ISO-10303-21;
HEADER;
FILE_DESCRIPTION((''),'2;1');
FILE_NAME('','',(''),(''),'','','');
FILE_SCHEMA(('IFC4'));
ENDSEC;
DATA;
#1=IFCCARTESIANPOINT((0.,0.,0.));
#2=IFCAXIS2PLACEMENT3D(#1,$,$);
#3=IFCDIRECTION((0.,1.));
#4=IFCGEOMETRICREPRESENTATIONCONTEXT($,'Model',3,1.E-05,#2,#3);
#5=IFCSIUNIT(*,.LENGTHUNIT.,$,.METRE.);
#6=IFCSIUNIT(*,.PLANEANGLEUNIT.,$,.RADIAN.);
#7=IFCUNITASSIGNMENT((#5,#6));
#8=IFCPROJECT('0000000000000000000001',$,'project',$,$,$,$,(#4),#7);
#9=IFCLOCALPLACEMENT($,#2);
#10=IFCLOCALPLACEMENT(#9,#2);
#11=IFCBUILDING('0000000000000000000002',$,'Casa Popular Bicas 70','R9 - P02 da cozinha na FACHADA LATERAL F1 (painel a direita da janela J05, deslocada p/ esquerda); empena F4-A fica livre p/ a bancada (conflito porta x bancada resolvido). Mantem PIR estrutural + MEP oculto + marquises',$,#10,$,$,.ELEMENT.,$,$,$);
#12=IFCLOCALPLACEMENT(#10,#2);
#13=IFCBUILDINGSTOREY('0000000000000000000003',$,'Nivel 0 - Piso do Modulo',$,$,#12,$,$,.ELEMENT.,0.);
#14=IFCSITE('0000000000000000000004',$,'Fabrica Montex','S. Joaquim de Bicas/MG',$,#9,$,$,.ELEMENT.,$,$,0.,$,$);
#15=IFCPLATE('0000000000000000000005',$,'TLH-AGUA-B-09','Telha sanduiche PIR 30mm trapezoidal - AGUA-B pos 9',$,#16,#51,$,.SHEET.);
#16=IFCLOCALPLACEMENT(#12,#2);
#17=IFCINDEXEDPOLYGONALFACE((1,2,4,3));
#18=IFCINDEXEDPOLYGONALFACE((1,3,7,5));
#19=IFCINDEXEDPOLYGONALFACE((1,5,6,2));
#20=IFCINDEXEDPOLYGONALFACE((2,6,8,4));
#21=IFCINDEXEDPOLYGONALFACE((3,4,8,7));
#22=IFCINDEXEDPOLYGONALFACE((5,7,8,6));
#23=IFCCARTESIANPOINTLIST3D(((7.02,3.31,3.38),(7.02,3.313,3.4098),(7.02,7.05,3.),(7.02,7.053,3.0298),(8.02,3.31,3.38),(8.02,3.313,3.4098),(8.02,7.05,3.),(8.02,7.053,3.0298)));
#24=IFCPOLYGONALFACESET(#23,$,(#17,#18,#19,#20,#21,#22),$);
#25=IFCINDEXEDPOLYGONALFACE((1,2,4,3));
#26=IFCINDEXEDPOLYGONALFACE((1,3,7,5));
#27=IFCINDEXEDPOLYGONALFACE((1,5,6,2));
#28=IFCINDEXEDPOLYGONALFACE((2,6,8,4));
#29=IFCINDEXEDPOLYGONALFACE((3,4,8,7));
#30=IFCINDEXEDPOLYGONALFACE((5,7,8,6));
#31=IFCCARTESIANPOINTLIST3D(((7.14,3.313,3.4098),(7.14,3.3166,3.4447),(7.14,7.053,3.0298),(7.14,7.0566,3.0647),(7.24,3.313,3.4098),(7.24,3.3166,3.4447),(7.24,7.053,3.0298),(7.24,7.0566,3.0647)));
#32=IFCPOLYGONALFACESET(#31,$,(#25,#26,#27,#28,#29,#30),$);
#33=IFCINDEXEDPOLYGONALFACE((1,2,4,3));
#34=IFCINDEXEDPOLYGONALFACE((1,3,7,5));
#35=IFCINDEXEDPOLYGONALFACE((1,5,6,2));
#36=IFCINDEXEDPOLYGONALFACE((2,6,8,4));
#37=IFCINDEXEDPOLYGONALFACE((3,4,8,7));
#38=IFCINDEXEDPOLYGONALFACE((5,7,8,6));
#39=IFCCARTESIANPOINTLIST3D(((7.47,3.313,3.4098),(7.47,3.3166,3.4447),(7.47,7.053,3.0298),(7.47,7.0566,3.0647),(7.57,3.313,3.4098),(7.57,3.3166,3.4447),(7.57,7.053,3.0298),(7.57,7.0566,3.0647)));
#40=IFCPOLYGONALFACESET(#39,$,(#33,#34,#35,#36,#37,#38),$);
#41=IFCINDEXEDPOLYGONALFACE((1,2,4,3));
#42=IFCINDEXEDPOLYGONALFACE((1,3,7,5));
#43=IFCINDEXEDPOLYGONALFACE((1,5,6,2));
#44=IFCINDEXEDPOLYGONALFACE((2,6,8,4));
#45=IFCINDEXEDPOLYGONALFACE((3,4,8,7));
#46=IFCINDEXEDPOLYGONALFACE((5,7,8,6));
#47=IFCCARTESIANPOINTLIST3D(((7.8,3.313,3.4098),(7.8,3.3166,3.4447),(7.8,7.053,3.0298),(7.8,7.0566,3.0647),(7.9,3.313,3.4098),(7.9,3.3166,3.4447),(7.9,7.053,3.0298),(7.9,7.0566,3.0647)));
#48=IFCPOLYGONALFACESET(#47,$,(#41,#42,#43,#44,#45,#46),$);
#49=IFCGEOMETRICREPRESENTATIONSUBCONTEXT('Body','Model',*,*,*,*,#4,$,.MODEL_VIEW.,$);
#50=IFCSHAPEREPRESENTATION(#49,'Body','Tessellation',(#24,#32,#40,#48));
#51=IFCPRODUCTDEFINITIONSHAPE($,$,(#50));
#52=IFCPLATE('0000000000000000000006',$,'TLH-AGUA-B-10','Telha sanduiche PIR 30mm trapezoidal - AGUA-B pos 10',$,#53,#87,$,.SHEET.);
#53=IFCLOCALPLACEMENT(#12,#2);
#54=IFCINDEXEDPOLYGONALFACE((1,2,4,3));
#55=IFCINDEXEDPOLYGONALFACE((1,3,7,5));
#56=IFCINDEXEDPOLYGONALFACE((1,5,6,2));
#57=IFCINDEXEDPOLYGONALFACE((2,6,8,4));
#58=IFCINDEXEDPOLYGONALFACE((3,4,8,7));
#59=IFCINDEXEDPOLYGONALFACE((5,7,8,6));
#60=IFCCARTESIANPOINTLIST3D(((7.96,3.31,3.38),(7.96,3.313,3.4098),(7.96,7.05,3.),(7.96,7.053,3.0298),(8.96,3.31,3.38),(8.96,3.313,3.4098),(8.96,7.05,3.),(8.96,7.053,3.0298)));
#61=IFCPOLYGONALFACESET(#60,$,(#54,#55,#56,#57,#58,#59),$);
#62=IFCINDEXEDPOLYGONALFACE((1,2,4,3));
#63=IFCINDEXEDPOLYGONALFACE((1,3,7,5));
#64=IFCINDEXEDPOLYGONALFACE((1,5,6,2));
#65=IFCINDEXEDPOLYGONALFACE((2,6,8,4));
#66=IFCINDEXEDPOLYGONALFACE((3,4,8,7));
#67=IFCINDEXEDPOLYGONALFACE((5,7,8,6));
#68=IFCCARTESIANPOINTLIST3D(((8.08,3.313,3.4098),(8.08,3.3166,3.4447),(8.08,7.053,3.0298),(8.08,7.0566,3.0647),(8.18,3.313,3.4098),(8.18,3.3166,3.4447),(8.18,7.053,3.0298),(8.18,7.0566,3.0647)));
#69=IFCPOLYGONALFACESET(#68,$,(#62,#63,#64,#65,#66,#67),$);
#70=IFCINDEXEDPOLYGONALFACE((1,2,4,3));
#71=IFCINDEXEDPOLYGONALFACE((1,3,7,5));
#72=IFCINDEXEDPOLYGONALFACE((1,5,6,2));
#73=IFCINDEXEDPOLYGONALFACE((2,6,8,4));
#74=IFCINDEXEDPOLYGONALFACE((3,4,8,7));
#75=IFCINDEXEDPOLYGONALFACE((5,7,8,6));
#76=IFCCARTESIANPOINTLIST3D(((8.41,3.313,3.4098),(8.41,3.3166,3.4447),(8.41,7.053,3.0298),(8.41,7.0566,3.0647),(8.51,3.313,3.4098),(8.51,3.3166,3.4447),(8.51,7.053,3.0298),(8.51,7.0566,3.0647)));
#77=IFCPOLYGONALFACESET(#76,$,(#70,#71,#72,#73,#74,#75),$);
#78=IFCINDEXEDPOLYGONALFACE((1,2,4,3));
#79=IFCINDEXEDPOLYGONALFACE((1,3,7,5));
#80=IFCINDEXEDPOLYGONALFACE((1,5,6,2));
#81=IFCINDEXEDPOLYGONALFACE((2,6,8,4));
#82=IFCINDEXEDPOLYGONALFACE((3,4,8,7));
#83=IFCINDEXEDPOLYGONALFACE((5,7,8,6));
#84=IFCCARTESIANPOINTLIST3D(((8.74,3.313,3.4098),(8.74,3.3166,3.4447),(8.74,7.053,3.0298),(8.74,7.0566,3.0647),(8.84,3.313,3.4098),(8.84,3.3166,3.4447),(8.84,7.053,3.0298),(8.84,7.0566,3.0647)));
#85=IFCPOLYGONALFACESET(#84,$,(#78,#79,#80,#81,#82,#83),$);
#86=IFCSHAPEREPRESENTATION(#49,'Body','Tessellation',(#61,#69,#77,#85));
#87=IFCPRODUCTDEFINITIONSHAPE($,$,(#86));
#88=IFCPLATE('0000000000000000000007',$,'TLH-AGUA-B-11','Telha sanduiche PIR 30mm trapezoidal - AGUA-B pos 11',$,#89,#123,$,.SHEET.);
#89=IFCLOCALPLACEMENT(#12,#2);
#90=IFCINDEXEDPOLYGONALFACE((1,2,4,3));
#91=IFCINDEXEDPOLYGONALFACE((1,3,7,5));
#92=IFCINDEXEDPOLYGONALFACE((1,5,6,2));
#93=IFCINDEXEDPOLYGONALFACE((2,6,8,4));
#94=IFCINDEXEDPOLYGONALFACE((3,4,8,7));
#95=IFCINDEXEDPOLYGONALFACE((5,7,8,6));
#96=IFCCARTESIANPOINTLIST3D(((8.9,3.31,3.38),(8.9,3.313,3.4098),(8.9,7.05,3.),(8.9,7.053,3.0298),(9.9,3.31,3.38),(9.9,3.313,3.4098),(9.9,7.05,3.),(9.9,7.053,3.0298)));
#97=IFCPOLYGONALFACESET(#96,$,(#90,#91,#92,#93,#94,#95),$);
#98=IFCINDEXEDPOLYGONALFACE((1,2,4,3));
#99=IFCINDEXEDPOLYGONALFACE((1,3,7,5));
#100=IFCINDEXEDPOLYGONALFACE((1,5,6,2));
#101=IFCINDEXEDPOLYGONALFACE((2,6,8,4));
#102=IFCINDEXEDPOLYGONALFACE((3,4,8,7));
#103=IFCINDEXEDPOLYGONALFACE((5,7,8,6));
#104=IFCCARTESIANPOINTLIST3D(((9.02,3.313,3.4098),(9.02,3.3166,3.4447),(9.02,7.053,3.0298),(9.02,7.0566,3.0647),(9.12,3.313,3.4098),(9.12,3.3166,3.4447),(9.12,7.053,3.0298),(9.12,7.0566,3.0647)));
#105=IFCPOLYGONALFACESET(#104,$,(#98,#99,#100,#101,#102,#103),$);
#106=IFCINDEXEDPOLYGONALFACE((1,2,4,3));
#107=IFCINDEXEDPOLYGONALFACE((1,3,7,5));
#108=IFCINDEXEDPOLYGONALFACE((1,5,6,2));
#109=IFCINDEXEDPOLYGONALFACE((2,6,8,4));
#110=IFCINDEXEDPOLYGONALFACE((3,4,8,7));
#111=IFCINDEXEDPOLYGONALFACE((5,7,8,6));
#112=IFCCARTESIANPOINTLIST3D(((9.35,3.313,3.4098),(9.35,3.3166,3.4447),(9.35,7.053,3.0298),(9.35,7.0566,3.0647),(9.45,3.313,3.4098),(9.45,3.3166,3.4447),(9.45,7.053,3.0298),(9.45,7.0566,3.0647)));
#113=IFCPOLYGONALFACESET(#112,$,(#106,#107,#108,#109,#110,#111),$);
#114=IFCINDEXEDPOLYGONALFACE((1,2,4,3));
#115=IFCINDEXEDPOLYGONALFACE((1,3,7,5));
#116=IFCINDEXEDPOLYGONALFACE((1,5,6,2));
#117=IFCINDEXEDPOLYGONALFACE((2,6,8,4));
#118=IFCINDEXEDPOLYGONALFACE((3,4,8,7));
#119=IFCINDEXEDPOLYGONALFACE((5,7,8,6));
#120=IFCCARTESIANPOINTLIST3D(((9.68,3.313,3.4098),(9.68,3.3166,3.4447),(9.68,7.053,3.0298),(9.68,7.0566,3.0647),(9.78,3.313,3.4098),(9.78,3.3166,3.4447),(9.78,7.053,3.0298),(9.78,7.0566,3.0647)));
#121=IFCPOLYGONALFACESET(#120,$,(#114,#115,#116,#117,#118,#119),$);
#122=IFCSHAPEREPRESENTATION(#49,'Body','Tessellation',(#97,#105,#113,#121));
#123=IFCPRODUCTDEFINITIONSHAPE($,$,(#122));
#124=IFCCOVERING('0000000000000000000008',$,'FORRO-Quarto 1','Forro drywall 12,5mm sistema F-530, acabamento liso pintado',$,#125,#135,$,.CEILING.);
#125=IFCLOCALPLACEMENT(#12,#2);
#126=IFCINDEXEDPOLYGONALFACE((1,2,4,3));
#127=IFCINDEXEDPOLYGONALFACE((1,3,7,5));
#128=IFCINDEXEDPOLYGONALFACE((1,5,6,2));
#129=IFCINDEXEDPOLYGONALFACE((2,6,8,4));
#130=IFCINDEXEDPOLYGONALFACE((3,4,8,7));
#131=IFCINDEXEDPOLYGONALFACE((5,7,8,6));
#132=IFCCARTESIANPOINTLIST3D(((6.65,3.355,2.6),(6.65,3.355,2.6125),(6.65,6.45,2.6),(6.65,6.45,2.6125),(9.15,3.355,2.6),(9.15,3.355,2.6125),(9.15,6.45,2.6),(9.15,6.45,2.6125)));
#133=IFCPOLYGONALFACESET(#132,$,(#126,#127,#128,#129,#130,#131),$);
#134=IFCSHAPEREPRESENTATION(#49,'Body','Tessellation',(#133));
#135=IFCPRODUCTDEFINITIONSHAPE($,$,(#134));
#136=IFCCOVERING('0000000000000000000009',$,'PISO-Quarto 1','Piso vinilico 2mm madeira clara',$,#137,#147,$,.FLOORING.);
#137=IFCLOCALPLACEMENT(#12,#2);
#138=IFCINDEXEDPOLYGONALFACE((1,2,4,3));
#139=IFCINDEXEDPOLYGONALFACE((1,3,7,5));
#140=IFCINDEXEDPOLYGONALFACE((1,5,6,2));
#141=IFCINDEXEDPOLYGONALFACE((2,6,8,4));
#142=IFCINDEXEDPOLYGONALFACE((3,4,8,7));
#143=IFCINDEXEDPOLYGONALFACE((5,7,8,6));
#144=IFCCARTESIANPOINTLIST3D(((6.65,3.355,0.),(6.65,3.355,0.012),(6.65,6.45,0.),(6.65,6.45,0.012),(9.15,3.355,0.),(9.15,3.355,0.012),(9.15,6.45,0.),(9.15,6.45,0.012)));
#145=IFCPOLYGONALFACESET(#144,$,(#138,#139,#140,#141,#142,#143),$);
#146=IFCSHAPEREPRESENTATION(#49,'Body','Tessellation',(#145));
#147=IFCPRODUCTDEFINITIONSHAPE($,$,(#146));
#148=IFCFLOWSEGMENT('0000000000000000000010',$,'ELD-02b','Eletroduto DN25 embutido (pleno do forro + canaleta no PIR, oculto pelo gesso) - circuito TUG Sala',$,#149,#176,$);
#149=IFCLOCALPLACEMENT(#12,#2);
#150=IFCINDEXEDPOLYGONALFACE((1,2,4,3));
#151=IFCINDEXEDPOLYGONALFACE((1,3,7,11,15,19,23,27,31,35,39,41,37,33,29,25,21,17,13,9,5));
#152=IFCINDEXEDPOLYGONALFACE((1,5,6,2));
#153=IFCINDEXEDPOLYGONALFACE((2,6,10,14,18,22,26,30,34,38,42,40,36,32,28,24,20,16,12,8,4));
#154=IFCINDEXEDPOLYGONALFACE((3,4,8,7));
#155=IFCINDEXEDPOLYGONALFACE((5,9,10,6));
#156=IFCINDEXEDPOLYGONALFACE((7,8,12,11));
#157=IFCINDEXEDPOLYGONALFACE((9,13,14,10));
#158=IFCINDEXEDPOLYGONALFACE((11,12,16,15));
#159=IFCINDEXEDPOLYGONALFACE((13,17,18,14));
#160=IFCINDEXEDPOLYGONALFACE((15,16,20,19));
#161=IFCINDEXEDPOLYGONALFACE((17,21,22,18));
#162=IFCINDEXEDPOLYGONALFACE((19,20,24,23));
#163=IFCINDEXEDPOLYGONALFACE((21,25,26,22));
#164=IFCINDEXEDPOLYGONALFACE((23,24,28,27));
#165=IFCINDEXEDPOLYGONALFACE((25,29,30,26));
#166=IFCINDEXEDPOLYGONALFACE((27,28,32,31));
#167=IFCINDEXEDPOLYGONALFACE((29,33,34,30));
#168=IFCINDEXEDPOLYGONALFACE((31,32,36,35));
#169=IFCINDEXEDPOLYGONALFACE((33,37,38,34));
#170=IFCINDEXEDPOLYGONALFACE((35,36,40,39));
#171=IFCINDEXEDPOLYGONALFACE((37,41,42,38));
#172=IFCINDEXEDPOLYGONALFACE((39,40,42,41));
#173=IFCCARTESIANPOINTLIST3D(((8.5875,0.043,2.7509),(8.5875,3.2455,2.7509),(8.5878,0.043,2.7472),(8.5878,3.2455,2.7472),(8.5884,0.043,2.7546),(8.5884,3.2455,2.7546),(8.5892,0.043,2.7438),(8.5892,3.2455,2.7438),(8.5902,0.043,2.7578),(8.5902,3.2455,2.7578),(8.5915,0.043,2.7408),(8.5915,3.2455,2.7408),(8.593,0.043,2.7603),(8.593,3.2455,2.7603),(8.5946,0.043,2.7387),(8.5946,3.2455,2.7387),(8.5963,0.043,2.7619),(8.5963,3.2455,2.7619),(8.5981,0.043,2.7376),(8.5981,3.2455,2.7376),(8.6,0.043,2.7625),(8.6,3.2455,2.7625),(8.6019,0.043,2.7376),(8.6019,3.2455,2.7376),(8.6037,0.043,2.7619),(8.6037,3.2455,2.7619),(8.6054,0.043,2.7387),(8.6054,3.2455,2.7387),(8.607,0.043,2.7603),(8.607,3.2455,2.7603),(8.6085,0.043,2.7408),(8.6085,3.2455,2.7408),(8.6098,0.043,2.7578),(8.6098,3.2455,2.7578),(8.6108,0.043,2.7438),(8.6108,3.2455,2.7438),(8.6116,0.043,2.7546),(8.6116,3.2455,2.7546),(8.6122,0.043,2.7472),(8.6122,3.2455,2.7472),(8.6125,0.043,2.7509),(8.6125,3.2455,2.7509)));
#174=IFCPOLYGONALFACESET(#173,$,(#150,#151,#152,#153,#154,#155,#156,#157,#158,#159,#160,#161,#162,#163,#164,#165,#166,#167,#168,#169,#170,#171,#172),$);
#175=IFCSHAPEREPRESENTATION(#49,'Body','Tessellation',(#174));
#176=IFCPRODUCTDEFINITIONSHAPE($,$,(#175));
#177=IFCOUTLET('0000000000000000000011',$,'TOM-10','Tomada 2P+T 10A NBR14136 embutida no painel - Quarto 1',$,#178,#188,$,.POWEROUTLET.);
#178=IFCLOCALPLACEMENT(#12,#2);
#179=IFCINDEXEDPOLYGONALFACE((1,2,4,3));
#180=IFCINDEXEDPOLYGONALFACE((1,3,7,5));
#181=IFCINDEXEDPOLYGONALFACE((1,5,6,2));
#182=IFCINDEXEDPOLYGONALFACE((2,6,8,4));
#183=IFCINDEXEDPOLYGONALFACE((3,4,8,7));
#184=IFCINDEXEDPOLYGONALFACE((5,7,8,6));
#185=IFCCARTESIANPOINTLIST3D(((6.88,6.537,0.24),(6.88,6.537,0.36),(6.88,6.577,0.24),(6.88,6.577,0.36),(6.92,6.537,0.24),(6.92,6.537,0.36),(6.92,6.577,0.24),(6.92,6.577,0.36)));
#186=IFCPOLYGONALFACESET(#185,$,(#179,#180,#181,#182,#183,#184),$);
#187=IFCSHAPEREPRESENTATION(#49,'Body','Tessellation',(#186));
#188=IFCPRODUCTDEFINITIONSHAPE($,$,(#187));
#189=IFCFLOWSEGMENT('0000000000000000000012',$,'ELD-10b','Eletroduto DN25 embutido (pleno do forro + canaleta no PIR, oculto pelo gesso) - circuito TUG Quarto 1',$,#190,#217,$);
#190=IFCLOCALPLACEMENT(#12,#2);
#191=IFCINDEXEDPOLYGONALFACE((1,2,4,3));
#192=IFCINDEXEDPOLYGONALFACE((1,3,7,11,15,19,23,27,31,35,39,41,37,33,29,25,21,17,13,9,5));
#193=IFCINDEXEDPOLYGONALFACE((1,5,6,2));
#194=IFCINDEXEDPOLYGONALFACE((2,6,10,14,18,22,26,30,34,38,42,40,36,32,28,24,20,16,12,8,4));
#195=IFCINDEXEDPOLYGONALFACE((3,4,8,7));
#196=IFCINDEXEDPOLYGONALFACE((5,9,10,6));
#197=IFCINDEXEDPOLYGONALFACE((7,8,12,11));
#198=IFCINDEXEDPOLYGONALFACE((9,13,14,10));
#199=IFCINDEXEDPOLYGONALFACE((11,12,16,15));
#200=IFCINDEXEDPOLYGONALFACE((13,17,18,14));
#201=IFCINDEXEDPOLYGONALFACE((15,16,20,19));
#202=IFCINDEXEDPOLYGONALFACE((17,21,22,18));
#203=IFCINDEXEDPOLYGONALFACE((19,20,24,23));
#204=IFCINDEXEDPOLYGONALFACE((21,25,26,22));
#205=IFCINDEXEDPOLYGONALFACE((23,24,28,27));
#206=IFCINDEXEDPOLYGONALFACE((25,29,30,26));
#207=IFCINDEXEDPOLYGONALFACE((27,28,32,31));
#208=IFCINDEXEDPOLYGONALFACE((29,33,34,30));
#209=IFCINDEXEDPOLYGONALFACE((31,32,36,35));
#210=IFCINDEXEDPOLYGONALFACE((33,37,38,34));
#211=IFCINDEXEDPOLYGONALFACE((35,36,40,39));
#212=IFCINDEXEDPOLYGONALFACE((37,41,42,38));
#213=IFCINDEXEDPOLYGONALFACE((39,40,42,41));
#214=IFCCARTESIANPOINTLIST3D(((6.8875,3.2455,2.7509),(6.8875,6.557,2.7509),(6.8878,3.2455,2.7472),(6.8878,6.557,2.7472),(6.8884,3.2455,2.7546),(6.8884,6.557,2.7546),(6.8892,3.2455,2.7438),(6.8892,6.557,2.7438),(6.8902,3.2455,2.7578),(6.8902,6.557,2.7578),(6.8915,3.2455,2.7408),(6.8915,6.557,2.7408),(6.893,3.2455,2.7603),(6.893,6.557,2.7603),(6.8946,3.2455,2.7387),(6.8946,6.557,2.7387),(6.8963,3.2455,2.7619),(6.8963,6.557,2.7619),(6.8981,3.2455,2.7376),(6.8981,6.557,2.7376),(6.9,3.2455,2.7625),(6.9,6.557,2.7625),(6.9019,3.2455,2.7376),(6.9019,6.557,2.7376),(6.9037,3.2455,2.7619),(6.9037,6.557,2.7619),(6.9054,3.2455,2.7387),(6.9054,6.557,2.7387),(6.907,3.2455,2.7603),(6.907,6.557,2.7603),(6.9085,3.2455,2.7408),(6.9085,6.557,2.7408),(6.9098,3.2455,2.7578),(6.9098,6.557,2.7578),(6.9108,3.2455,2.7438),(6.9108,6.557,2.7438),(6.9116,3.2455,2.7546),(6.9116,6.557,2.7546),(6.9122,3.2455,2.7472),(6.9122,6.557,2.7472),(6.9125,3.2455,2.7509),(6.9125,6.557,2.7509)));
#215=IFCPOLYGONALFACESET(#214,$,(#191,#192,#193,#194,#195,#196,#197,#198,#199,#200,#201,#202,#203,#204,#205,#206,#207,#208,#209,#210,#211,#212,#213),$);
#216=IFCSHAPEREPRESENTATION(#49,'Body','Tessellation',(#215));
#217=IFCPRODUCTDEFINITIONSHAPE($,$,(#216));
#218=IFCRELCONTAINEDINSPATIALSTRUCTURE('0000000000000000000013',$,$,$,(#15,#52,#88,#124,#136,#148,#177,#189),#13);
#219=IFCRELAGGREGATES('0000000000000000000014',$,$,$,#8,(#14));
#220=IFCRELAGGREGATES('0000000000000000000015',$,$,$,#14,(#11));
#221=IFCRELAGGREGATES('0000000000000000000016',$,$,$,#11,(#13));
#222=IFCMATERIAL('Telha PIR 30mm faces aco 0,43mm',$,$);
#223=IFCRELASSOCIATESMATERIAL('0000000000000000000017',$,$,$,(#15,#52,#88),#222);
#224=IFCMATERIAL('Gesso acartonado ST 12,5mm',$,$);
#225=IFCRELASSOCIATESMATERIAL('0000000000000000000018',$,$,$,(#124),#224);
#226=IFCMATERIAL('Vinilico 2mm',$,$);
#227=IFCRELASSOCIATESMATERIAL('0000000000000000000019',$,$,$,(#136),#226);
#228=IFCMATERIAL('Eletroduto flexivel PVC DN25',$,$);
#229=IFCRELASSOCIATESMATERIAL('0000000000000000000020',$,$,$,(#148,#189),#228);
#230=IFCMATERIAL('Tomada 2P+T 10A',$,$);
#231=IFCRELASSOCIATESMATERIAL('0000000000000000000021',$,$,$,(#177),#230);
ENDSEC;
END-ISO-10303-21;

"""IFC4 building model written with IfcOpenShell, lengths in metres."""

from ifc_helpers import new_model, si_unit, direction, frame, frame_2d, origin, origin_2d, place, context, subcontext, project, spatial, rectangle, circle, extrude, material, element, save


model = new_model("IFC4")

# Units and contexts
model_context = context("Model", 3, precision=1e-05, world=origin(), true_north=direction((0.0, 1.0)))
body_context = subcontext(model_context, "Body", "Model", "MODEL_VIEW")
ifc_project = project(units=[si_unit("LENGTHUNIT", "METRE"), si_unit("PLANEANGLEUNIT", "RADIAN")], contexts=[model_context])

# Site, building, storey
site_placement = place(None, origin())
site = spatial("IfcSite", under=ifc_project, at=site_placement, Name="Fabrica Montex", Description="S. Joaquim de Bicas/MG", CompositionType="ELEMENT", RefElevation=0.0)
building_placement = place(site_placement, origin())
building = spatial("IfcBuilding", under=site, at=building_placement, Name="Casa Popular Bicas 70", Description="R9 - P02 da cozinha na FACHADA LATERAL F1 (painel a direita da janela J05, deslocada p/ esquerda); empena F4-A fica livre p/ a bancada (conflito porta x bancada resolvido). Mantem PIR estrutural + MEP oculto + marquises", CompositionType="ELEMENT")
storey_placement = place(building_placement, origin())
storey = spatial("IfcBuildingStorey", under=building, at=storey_placement, Name="Nivel 0 - Piso do Modulo", CompositionType="ELEMENT", Elevation=0.0)

# Plates
ifc_material_1 = material(Name="Telha PIR 30mm faces aco 0,43mm")
for number, where, z_axis, x_axis, name, description in (
    (1, (7.02, 3.31, 3.38), (0.0, 0.101084, 0.994878), (1.0, 0.0, 0.0), "TLH-AGUA-B-09", "Telha sanduiche PIR 30mm trapezoidal - AGUA-B pos 9"),
    (2, (7.96, 3.31, 3.38), (0.0, 0.101084, 0.994878), (1.0, 0.0, 0.0), "TLH-AGUA-B-10", "Telha sanduiche PIR 30mm trapezoidal - AGUA-B pos 10"),
    (3, (8.9, 3.31, 3.38), (0.0, 0.101084, 0.994878), (1.0, 0.0, 0.0), "TLH-AGUA-B-11", "Telha sanduiche PIR 30mm trapezoidal - AGUA-B pos 11"),
):
    element("IfcPlate", number, at=place(storey_placement, frame(where, z_axis=z_axis, x_axis=x_axis)), inside=storey, material=ifc_material_1, Name=name, Description=description, PredefinedType="SHEET", context=body_context, shape_type="SweptSolid", body=[
        extrude(rectangle(XDim=1.0, YDim=3.7593, at=frame_2d((0.5, 1.8796))), origin(), (0.0, 0.0, 1.0), 0.03),
        extrude(rectangle(XDim=0.1, YDim=3.7593, at=frame_2d((0.17, 1.8796))), frame((0.0, 0.0, 0.03)), (0.0, 0.0, 1.0), 0.035),
        extrude(rectangle(XDim=0.1, YDim=3.7593, at=frame_2d((0.5, 1.8796))), frame((0.0, 0.0, 0.03)), (0.0, 0.0, 1.0), 0.035),
        extrude(rectangle(XDim=0.1, YDim=3.7593, at=frame_2d((0.83, 1.8796))), frame((0.0, 0.0, 0.03)), (0.0, 0.0, 1.0), 0.035),
    ])

# Coverings
ifc_material_2 = material(Name="Gesso acartonado ST 12,5mm")
covering_1_placement = place(storey_placement, frame((6.65, 3.355, 2.6)))
element("IfcCovering", 4, at=covering_1_placement, inside=storey, material=ifc_material_2, Name="FORRO-Quarto 1", Description="Forro drywall 12,5mm sistema F-530, acabamento liso pintado", PredefinedType="CEILING", context=body_context, shape_type="SweptSolid", body=[
    extrude(rectangle(XDim=2.5, YDim=3.095, at=frame_2d((1.25, 1.5475))), origin(), (0.0, 0.0, 1.0), 0.0125),
])
ifc_material_3 = material(Name="Vinilico 2mm")
covering_2_placement = place(storey_placement, frame((6.65, 3.355, 0.0)))
element("IfcCovering", 5, at=covering_2_placement, inside=storey, material=ifc_material_3, Name="PISO-Quarto 1", Description="Piso vinilico 2mm madeira clara", PredefinedType="FLOORING", context=body_context, shape_type="SweptSolid", body=[
    extrude(rectangle(XDim=2.5, YDim=3.095, at=frame_2d((1.25, 1.5475))), origin(), (0.0, 0.0, 1.0), 0.012),
])

# Flow segment
ifc_material_4 = material(Name="Eletroduto flexivel PVC DN25")
flow_segment_1_placement = place(storey_placement, frame((8.6, 3.2455, 2.75), z_axis=(0.0, -1.0, 0.0), x_axis=(0.0, 0.0, 1.0)))
element("IfcFlowSegment", 6, at=flow_segment_1_placement, inside=storey, material=ifc_material_4, Name="ELD-02b", Description="Eletroduto DN25 embutido (pleno do forro + canaleta no PIR, oculto pelo gesso) - circuito TUG Sala", context=body_context, shape_type="SweptSolid", body=[
    extrude(circle(Radius=0.0125, at=origin_2d()), origin(), (0.0, 0.0, 1.0), 3.2025),
])

# Outlet
ifc_material_5 = material(Name="Tomada 2P+T 10A")
outlet_1_placement = place(storey_placement, frame((6.88, 6.537, 0.24)))
element("IfcOutlet", 7, at=outlet_1_placement, inside=storey, material=ifc_material_5, Name="TOM-10", Description="Tomada 2P+T 10A NBR14136 embutida no painel - Quarto 1", PredefinedType="POWEROUTLET", context=body_context, shape_type="SweptSolid", body=[
    extrude(rectangle(XDim=0.04, YDim=0.04, at=frame_2d((0.02, 0.02))), origin(), (0.0, 0.0, 1.0), 0.12),
])

# Flow segment
flow_segment_2_placement = place(storey_placement, frame((6.9, 3.2455, 2.75), z_axis=(0.0, 1.0, 0.0), x_axis=(0.0, 0.0, 1.0)))
element("IfcFlowSegment", 8, at=flow_segment_2_placement, inside=storey, material=ifc_material_4, Name="ELD-10b", Description="Eletroduto DN25 embutido (pleno do forro + canaleta no PIR, oculto pelo gesso) - circuito TUG Quarto 1", context=body_context, shape_type="SweptSolid", body=[
    extrude(circle(Radius=0.0125, at=origin_2d()), origin(), (0.0, 0.0, 1.0), 3.3115),
])

save(model, "model.ifc")
